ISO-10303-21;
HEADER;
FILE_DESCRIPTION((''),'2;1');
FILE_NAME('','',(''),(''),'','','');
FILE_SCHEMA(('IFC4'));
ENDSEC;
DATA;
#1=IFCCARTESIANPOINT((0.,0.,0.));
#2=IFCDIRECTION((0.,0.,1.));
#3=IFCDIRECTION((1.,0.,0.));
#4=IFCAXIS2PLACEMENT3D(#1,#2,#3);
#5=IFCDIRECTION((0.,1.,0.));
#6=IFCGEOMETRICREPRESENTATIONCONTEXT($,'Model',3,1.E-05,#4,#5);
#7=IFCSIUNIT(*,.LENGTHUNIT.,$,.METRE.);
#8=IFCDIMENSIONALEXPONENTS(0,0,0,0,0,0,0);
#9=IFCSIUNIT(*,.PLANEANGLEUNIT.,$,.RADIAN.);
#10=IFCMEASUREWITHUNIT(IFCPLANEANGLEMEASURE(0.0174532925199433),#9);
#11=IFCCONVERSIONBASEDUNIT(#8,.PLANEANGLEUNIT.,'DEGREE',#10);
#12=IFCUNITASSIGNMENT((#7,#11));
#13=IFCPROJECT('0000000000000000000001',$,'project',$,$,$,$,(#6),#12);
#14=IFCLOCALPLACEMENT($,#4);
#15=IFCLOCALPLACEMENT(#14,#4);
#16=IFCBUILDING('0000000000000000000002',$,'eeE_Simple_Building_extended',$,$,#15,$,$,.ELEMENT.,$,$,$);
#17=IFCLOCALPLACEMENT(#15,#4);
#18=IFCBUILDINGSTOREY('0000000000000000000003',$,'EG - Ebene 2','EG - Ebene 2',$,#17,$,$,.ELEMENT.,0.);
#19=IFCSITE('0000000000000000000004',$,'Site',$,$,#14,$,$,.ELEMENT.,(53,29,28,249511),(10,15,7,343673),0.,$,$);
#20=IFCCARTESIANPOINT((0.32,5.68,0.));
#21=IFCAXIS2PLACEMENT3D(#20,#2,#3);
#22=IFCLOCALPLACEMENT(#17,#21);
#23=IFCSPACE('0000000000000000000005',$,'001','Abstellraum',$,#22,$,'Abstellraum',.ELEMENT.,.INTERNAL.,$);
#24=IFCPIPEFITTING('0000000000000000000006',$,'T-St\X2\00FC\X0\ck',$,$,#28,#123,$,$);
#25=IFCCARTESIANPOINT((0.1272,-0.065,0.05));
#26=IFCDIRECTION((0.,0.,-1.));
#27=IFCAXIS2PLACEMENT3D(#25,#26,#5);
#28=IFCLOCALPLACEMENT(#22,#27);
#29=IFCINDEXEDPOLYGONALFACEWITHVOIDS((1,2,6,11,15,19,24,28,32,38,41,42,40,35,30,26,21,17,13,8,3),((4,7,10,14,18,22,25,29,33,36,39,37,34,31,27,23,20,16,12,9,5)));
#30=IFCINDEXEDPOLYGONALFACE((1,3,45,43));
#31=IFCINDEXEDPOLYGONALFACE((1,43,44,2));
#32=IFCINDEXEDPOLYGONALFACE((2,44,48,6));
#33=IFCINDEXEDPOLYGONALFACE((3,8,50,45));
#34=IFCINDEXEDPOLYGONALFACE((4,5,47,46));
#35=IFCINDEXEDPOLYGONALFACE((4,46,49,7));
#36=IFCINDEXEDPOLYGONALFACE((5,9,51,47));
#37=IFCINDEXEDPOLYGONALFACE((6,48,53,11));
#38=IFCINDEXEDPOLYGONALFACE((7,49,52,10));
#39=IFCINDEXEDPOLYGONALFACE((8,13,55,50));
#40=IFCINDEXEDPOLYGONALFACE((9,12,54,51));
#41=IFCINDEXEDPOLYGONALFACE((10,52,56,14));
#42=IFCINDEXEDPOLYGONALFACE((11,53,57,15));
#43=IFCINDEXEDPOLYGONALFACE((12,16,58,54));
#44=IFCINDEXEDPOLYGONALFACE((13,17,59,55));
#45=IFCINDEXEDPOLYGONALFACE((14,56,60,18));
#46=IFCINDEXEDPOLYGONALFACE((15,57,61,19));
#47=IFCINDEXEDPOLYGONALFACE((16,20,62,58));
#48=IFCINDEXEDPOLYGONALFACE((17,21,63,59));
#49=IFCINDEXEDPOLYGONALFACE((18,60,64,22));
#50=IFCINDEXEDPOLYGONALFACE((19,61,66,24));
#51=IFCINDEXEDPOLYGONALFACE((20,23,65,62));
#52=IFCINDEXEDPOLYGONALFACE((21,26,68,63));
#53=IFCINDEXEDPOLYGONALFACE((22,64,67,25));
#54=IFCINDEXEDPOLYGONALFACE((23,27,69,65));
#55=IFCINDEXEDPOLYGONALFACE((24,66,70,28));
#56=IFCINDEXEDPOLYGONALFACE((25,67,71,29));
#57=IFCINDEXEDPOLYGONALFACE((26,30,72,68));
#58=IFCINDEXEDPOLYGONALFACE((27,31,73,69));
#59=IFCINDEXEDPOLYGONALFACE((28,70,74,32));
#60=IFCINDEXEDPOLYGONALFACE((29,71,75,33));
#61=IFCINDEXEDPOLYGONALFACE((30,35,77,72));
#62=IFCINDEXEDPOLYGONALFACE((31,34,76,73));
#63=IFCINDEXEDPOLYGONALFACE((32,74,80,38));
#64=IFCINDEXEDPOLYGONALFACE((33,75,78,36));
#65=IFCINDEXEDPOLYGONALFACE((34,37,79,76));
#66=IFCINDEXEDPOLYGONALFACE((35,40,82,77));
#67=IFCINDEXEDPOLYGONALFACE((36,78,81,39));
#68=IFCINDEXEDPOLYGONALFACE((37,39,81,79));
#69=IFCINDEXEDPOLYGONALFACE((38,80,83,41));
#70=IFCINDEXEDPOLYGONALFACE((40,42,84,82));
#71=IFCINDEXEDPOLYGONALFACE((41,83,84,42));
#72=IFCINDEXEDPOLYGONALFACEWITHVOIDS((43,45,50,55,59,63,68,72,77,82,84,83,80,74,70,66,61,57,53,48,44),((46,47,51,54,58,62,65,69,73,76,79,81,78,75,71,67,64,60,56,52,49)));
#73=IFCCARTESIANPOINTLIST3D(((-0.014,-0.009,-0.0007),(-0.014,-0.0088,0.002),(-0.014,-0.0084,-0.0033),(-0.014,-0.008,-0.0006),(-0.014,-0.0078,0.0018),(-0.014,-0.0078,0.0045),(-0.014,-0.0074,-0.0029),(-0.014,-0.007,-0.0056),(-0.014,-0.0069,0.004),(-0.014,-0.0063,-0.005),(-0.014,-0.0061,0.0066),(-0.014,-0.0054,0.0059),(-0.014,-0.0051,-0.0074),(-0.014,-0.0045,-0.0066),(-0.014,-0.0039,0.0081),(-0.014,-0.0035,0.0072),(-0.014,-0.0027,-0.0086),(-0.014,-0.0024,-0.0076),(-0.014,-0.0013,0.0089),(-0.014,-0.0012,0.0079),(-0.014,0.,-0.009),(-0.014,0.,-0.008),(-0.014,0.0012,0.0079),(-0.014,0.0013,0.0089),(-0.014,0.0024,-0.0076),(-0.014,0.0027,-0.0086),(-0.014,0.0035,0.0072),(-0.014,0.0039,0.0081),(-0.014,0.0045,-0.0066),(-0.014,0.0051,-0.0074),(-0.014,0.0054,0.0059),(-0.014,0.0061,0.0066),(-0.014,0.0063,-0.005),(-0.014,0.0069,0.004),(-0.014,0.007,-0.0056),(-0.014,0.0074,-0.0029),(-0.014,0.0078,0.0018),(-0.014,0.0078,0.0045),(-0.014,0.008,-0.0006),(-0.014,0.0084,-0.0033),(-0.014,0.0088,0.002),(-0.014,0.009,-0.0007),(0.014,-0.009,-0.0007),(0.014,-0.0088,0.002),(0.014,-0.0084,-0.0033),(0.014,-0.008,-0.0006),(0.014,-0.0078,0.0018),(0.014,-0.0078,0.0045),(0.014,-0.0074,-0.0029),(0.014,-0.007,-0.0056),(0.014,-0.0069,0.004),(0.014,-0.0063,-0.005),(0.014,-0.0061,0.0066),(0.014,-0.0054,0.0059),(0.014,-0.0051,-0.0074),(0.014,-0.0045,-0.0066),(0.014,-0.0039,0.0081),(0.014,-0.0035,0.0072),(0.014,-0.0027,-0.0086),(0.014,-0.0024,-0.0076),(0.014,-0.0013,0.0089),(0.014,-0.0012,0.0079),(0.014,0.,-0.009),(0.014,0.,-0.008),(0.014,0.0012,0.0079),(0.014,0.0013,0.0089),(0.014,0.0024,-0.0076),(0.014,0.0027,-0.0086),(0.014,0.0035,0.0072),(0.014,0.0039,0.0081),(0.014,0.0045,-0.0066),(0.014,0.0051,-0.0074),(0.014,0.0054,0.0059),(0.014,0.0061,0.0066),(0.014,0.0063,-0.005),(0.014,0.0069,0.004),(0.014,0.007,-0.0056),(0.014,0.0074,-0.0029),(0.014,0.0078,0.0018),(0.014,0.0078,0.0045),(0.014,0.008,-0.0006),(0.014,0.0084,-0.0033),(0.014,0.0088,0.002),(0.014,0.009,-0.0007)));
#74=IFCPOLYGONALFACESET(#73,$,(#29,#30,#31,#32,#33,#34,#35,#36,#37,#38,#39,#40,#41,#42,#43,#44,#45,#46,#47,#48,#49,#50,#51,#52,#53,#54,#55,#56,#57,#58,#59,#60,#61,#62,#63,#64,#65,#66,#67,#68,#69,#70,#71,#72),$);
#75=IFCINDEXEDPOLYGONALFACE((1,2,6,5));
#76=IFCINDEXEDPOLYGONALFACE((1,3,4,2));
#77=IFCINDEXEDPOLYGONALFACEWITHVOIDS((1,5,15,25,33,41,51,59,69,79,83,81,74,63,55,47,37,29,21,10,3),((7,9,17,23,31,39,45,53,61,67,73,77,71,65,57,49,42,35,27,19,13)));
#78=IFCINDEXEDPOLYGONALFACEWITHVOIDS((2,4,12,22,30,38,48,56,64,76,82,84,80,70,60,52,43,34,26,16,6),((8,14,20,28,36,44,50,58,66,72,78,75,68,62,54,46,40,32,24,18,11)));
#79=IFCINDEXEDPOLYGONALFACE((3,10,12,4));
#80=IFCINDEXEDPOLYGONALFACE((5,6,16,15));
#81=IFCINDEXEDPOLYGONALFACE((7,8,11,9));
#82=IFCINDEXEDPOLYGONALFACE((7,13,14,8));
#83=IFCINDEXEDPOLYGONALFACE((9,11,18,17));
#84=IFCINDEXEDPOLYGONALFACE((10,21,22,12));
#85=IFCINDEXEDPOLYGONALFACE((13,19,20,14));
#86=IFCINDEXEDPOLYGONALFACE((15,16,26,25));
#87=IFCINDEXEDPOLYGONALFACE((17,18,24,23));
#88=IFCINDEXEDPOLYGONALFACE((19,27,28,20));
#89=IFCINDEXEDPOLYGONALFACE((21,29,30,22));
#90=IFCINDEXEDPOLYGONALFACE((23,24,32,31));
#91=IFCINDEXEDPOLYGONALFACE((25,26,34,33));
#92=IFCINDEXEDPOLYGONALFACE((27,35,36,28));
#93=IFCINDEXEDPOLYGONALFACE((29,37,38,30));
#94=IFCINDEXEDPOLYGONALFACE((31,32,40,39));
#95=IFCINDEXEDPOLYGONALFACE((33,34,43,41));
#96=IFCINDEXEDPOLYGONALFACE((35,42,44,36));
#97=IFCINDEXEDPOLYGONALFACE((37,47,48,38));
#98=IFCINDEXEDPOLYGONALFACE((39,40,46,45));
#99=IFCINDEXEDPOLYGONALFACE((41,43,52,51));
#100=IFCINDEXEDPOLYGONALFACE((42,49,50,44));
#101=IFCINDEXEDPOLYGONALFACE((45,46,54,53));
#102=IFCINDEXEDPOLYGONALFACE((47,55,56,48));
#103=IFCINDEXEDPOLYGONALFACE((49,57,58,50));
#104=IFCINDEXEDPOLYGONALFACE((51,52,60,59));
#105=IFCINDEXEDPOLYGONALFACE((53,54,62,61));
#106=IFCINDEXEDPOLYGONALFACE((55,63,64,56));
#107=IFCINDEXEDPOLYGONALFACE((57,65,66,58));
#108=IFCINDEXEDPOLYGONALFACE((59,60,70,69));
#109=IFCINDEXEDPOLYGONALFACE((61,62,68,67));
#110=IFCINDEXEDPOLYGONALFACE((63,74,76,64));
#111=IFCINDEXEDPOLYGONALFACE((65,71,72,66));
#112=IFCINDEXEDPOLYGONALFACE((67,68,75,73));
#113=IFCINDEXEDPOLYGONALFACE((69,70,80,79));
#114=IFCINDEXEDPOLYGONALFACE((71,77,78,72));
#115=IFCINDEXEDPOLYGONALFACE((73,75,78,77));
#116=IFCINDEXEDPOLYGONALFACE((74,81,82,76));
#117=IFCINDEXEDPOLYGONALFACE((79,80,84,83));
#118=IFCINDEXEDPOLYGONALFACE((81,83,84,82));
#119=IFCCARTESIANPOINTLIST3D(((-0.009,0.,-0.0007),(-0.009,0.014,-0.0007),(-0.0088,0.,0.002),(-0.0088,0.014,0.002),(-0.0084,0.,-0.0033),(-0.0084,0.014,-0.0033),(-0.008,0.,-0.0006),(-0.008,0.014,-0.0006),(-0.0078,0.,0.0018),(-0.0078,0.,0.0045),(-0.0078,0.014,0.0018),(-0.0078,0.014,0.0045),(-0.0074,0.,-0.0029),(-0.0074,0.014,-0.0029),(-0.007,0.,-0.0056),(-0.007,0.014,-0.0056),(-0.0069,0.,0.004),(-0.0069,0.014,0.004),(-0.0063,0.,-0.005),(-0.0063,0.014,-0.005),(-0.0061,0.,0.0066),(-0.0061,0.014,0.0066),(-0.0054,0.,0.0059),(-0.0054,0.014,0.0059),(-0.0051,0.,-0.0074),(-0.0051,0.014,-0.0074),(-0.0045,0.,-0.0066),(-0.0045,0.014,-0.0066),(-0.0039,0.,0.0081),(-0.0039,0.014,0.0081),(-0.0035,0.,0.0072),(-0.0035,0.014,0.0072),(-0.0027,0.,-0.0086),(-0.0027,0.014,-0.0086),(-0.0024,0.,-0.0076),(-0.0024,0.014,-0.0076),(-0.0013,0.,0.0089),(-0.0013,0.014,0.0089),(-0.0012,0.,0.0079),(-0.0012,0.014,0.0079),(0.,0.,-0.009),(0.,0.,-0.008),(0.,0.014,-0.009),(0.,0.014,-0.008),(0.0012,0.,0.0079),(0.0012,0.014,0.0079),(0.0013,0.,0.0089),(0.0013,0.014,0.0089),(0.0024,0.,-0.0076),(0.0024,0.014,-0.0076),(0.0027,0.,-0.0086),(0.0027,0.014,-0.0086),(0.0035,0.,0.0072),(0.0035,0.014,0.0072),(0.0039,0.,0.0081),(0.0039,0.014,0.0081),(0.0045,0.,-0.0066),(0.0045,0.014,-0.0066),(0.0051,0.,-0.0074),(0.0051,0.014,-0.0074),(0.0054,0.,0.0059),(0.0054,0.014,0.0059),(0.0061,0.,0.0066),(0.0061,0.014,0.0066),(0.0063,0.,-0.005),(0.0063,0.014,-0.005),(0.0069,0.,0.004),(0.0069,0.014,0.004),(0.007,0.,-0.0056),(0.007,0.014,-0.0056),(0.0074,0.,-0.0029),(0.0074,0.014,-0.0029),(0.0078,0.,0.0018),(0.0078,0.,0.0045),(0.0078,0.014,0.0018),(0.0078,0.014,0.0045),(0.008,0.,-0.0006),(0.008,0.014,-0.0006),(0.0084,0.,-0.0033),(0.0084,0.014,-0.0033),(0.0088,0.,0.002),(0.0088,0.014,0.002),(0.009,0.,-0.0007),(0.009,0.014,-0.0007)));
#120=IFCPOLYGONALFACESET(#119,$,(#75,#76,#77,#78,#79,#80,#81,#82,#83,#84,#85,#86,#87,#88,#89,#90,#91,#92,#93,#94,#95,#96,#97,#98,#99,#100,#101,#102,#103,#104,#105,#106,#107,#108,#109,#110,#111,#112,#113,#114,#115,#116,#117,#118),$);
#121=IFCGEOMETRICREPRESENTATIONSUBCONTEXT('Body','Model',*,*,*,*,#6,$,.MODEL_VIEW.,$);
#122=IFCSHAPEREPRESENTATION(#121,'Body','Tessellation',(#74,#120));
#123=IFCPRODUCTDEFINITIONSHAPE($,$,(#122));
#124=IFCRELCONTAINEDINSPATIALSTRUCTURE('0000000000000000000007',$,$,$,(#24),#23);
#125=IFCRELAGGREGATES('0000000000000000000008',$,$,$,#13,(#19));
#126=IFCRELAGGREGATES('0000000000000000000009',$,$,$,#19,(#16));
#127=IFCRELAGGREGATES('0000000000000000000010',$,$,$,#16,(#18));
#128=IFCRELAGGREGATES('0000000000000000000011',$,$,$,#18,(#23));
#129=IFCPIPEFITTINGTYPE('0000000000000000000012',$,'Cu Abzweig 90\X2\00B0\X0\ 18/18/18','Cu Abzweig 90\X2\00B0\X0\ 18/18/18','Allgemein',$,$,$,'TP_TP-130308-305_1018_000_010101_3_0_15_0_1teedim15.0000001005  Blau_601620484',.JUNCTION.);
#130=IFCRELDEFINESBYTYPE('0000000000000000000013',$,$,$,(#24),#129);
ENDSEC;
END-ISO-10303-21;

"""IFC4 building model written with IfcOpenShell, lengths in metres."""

from ifc_helpers import new_model, entity, si_unit, converted_unit, direction, frame, origin_with_axes, origin_2d_with_axis, place, context, subcontext, project, spatial, hollow_circle, extrude, source, transform, mapped, type_object, element, save


model = new_model("IFC4")

# Units and contexts
model_context = context("Model", 3, precision=1e-05, world=origin_with_axes(), true_north=direction((0.0, 1.0, 0.0)))
body_context = subcontext(model_context, "Body", "Model", "MODEL_VIEW")
ifc_project = project(units=[si_unit("LENGTHUNIT", "METRE"), converted_unit("PLANEANGLEUNIT", "DEGREE", entity("IfcPlaneAngleMeasure", 0.0174532925199433), si_unit("PLANEANGLEUNIT", "RADIAN"), dimensions=[0, 0, 0, 0, 0, 0, 0])], contexts=[model_context])

# Site, building, storey, space
site_placement = place(None, origin_with_axes())
site = spatial("IfcSite", under=ifc_project, at=site_placement, Name="Site", CompositionType="ELEMENT", RefLatitude=(53, 29, 28, 249511), RefLongitude=(10, 15, 7, 343673), RefElevation=0.0)
building_placement = place(site_placement, origin_with_axes())
building = spatial("IfcBuilding", under=site, at=building_placement, Name="eeE_Simple_Building_extended", CompositionType="ELEMENT")
storey_placement = place(building_placement, origin_with_axes())
storey = spatial("IfcBuildingStorey", under=building, at=storey_placement, Name="EG - Ebene 2", Description="EG - Ebene 2", CompositionType="ELEMENT", Elevation=0.0)
space_placement = place(storey_placement, frame((0.32, 5.68, 0.0), z_axis=(0.0, 0.0, 1.0), x_axis=(1.0, 0.0, 0.0)))
space = spatial("IfcSpace", under=storey, at=space_placement, Name="001", Description="Abstellraum", LongName="Abstellraum", CompositionType="ELEMENT", PredefinedType="INTERNAL")

# Pipe fitting
pipe_fitting_type_1 = type_object("IfcPipeFittingType", Name="Cu Abzweig 90° 18/18/18", Description="Cu Abzweig 90° 18/18/18", ApplicableOccurrence="Allgemein", ElementType="TP_TP-130308-305_1018_000_010101_3_0_15_0_1teedim15.0000001005  Blau_601620484", PredefinedType="JUNCTION")
shared_shape_1 = source(origin_with_axes(), body_context, "Body", "SweptSolid", [
    extrude(hollow_circle(Radius=0.009, WallThickness=0.001, at=origin_2d_with_axis()), frame((0.0, 0.0, 0.0), z_axis=(1.0, 0.0, 0.0), x_axis=(0.0, 0.0, -1.0)), (0.0, 0.0, 1.0), 0.028),
    extrude(hollow_circle(Radius=0.009, WallThickness=0.001, at=origin_2d_with_axis()), frame((0.014, 0.0, 0.0), z_axis=(0.0, 1.0, 0.0), x_axis=(0.0, 0.0, -1.0)), (0.0, 0.0, 1.0), 0.014),
])
pipe_fitting_1_placement = place(space_placement, frame((0.1272, -0.065, 0.05), z_axis=(0.0, 0.0, -1.0), x_axis=(0.0, 1.0, 0.0)))
element("IfcPipeFitting", 1, at=pipe_fitting_1_placement, inside=space, type_object=pipe_fitting_type_1, Name="T-Stück", context=body_context, shape_type="MappedRepresentation", body=[
    mapped(shared_shape_1, transform((-0.014, 0.0, 0.0), x_axis=(1.0, 0.0, 0.0), y_axis=(0.0, 1.0, 0.0), z_axis=(0.0, 0.0, 1.0), scale=1.0)),
])

save(model, "model.ifc")
